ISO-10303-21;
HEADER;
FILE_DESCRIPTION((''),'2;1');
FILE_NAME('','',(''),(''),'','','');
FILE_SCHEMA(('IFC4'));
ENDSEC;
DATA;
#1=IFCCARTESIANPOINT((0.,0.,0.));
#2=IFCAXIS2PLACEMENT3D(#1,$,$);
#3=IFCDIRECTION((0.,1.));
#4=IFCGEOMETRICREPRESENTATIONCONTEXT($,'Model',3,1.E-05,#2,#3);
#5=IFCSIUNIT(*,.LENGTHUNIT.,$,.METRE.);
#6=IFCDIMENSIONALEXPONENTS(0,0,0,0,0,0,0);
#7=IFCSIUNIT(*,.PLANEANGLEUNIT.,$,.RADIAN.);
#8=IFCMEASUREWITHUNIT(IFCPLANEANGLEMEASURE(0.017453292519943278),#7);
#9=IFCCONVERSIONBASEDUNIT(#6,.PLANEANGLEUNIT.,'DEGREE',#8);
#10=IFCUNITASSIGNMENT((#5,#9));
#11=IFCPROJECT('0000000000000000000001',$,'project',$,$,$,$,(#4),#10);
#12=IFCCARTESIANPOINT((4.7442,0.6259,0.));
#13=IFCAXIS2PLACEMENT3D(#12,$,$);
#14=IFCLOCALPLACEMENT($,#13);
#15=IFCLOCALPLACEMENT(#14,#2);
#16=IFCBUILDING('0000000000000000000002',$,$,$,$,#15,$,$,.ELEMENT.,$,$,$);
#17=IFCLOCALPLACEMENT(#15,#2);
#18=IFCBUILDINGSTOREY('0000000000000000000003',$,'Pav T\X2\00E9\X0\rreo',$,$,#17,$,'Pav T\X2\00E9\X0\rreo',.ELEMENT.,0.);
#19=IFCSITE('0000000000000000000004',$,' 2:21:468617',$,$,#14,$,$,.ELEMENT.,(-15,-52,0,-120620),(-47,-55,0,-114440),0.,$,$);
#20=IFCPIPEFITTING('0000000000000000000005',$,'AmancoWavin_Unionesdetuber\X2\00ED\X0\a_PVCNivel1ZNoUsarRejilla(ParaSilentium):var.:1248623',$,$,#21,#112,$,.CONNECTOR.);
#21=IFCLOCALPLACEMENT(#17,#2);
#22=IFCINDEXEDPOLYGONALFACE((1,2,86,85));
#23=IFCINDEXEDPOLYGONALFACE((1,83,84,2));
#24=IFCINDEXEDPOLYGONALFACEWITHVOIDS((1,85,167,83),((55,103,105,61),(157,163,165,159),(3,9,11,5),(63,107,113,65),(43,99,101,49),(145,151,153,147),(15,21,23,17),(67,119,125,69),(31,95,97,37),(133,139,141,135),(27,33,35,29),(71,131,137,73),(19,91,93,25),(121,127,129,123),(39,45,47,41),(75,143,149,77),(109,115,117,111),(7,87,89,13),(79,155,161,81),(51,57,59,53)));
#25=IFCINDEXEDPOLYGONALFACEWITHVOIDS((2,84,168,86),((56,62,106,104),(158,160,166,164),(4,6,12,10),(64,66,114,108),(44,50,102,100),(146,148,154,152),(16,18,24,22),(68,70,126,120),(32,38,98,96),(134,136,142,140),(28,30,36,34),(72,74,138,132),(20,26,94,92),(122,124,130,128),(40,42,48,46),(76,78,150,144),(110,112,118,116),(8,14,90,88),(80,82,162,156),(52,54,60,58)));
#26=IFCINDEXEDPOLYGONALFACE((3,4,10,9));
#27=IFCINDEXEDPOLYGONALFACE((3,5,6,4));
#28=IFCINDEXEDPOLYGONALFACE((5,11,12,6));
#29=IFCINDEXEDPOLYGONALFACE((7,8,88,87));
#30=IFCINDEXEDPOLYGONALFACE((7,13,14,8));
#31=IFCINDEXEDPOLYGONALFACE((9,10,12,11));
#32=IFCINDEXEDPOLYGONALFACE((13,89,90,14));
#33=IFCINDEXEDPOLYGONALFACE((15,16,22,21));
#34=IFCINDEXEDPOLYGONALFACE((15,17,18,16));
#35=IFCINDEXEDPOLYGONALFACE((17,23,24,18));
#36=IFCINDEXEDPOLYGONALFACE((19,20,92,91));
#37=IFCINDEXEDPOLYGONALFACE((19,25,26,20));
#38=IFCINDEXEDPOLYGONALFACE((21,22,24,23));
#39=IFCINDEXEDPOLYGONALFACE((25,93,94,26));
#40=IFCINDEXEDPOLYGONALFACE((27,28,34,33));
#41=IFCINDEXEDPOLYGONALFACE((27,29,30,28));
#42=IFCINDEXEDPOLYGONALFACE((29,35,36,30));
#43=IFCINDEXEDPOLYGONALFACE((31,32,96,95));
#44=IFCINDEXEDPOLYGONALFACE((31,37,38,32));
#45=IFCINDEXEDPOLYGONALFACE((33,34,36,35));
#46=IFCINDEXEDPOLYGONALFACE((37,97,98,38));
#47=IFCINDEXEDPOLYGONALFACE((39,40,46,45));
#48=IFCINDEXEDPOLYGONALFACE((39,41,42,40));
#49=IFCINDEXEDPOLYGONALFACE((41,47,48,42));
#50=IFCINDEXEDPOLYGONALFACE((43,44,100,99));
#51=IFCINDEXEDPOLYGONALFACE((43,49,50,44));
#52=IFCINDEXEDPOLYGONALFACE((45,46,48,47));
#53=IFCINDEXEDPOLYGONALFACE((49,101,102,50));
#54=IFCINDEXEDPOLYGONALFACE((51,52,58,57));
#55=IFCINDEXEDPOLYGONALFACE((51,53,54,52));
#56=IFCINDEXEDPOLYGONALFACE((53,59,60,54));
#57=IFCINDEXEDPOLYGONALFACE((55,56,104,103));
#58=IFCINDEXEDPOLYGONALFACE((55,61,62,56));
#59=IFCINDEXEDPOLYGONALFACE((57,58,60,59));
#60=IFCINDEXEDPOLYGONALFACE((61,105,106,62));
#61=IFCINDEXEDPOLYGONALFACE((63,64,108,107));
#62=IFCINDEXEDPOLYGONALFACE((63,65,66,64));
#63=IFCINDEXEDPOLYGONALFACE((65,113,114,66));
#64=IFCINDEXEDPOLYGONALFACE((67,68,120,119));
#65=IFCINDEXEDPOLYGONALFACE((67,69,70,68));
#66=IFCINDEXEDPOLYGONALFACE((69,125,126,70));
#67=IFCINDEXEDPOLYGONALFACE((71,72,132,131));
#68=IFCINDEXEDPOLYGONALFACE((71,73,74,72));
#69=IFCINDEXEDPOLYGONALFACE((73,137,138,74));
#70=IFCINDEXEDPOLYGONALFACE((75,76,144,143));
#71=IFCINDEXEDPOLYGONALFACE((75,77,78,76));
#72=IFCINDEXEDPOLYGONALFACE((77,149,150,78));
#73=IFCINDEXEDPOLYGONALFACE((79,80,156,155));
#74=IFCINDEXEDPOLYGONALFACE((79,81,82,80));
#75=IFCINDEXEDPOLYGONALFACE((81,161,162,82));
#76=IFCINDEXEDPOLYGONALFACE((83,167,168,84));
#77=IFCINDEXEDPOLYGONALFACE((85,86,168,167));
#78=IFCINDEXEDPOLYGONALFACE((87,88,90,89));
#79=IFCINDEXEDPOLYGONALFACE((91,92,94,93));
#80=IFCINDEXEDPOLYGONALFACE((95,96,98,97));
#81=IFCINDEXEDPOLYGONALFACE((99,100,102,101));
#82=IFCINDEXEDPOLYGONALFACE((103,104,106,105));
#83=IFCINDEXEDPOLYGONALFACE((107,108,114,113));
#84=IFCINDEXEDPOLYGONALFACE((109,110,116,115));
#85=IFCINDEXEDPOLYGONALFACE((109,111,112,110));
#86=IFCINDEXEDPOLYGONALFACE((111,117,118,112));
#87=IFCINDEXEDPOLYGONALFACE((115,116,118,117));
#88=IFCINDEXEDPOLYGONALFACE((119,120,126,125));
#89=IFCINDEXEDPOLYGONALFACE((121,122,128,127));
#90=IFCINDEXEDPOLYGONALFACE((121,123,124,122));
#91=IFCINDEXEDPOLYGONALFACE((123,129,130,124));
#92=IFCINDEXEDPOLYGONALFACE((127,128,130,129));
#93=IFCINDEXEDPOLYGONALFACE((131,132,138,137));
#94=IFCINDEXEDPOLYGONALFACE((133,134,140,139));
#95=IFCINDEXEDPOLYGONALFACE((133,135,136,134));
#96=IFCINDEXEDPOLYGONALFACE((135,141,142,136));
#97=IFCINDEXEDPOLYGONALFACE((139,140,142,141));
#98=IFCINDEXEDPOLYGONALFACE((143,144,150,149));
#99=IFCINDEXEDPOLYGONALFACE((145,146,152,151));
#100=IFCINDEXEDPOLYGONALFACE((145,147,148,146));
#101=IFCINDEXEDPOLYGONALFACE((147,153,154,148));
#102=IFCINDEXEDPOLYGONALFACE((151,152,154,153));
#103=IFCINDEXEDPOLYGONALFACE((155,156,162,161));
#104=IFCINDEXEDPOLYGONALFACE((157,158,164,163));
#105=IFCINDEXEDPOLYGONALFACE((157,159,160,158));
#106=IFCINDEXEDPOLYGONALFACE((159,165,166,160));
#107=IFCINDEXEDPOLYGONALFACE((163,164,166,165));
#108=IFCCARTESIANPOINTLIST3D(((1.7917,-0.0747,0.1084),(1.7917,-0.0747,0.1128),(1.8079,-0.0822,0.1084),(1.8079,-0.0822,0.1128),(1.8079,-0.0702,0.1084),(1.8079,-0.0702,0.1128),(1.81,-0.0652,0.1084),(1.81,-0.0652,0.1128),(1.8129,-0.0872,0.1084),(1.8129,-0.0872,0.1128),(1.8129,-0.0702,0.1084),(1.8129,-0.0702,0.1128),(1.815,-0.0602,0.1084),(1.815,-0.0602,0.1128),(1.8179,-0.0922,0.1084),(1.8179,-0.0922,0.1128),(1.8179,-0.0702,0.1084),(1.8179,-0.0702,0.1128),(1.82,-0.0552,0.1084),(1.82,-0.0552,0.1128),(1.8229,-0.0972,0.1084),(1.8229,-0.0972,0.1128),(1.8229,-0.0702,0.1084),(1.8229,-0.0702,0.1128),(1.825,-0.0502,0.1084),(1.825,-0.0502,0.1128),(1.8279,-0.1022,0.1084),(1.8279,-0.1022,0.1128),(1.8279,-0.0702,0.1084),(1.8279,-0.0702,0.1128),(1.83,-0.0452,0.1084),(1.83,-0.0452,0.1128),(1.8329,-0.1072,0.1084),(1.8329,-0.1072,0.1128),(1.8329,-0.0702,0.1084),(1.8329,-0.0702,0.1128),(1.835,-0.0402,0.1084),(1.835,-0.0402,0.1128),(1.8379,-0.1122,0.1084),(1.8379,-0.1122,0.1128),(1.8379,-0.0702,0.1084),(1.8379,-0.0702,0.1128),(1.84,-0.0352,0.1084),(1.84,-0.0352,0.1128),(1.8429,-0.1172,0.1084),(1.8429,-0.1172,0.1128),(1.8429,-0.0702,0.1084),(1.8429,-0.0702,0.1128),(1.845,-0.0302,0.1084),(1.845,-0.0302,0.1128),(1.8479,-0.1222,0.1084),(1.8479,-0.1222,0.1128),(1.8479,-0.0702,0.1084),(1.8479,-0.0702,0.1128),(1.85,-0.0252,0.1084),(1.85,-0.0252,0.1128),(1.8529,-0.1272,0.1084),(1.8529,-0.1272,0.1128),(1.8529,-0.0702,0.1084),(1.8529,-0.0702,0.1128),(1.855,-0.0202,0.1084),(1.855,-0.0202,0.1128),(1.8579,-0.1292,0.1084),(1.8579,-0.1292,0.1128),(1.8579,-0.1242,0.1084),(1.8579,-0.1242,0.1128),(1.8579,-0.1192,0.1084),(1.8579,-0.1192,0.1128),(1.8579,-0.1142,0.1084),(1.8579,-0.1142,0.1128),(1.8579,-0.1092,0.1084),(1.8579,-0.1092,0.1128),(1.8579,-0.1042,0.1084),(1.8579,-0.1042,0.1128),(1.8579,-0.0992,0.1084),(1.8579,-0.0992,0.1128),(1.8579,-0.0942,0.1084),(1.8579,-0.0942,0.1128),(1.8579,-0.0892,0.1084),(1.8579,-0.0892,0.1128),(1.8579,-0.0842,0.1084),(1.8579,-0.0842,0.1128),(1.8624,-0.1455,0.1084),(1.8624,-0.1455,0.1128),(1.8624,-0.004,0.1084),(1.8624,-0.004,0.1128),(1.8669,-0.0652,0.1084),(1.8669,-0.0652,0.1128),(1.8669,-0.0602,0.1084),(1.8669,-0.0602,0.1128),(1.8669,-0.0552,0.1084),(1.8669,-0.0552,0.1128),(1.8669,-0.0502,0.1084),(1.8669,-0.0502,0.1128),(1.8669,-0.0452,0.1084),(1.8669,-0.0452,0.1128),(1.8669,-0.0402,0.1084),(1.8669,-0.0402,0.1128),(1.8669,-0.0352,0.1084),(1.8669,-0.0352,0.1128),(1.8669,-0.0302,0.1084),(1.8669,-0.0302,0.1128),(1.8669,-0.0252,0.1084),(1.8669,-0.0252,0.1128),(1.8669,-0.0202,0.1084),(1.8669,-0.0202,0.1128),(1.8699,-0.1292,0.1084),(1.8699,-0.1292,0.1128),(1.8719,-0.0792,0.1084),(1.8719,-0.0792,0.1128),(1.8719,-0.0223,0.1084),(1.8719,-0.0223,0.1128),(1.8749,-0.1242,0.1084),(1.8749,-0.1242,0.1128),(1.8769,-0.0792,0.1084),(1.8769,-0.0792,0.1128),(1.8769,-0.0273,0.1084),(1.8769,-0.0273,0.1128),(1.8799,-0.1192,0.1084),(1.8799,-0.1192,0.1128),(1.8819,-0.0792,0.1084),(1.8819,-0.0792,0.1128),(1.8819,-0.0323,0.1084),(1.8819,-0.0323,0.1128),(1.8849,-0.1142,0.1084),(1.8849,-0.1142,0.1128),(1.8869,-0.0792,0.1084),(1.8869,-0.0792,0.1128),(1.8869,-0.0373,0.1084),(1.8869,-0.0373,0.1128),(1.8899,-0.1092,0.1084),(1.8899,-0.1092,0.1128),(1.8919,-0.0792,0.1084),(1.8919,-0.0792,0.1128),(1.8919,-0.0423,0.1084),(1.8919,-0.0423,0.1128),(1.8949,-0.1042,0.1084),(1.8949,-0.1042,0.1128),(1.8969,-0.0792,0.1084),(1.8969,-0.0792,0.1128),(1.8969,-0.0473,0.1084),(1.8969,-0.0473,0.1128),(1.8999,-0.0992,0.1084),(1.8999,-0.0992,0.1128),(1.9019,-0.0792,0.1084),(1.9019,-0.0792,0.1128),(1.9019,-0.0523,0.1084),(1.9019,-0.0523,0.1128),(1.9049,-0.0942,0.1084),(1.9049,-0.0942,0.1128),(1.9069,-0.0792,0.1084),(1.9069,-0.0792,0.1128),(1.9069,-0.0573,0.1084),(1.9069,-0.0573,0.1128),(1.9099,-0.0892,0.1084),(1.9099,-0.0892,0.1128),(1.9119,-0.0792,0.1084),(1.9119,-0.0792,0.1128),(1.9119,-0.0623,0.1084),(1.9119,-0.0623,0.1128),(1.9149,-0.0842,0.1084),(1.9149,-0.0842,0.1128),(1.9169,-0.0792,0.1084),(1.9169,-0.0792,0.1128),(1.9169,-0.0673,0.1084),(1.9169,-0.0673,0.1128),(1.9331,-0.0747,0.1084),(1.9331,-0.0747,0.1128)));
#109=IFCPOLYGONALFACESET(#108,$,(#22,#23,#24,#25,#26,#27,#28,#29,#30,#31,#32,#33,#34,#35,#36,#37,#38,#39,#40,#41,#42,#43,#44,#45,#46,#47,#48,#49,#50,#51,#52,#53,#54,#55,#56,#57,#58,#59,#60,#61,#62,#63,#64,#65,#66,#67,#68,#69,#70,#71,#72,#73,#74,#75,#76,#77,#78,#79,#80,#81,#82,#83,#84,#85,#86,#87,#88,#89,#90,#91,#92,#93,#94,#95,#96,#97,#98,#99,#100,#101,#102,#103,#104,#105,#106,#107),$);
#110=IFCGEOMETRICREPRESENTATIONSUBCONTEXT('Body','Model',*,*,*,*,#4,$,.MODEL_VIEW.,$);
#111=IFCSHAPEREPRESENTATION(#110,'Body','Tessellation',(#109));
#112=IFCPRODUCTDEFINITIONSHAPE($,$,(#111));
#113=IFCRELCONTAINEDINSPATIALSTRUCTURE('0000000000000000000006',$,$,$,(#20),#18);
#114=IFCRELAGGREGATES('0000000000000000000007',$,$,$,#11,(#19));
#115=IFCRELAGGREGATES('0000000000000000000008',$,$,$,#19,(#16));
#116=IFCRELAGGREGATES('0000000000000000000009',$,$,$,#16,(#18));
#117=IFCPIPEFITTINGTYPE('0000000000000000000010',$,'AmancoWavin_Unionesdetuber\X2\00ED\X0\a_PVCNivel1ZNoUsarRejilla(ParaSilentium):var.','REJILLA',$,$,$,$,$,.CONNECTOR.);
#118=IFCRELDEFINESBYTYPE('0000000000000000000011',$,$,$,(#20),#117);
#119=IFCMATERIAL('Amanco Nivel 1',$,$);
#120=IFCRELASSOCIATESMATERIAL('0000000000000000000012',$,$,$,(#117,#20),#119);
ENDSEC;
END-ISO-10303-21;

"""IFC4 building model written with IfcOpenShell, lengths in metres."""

from ifc_helpers import new_model, entity, si_unit, converted_unit, direction, frame, origin, place, context, subcontext, project, spatial, indexed_curve, outline, extrude, source, transform, mapped, material, type_object, type_shapes, element, save


model = new_model("IFC4")

# Units and contexts
model_context = context("Model", 3, precision=1e-05, world=origin(), true_north=direction((0.0, 1.0)))
body_context = subcontext(model_context, "Body", "Model", "MODEL_VIEW")
ifc_project = project(units=[si_unit("LENGTHUNIT", "METRE"), converted_unit("PLANEANGLEUNIT", "DEGREE", entity("IfcPlaneAngleMeasure", 0.017453292519943278), si_unit("PLANEANGLEUNIT", "RADIAN"), dimensions=[0, 0, 0, 0, 0, 0, 0])], contexts=[model_context])

# Site, building, storey
site_placement = place(None, frame((4.7442, 0.6259, 0.0)))
site = spatial("IfcSite", under=ifc_project, at=site_placement, Name=" 2:21:468617", CompositionType="ELEMENT", RefLatitude=(-15, -52, 0, -120620), RefLongitude=(-47, -55, 0, -114440), RefElevation=0.0)
building_placement = place(site_placement, origin())
building = spatial("IfcBuilding", under=site, at=building_placement, CompositionType="ELEMENT")
storey_placement = place(building_placement, origin())
storey = spatial("IfcBuildingStorey", under=building, at=storey_placement, Name="Pav Térreo", LongName="Pav Térreo", CompositionType="ELEMENT", Elevation=0.0)

# Pipe fitting
ifc_material = material(Name="Amanco Nivel 1")
pipe_fitting_type = type_object("IfcPipeFittingType", Name="AmancoWavin_Unionesdetubería_PVCNivel1ZNoUsarRejilla(ParaSilentium):var.", Description="REJILLA", PredefinedType="CONNECTOR", material=ifc_material)
shared_shape = source(origin(), body_context, "Body", "SweptSolid", [
    extrude(outline(indexed_curve([(-0.05, -0.05), (0.05, -0.05), (0.05, 0.05), (-0.05, 0.05), (-0.05, -0.05)], self_intersect=False), holes=[indexed_curve([(0.0417, 0.0354), (0.0382, 0.0318), (0.0262, 0.0438), (0.0333, 0.0438), (0.0417, 0.0354)], self_intersect=False), indexed_curve([(0.0346, 0.0283), (0.0311, 0.0247), (0.0121, 0.0438), (0.0191, 0.0438), (0.0346, 0.0283)], self_intersect=False), indexed_curve([(0.0276, 0.0212), (0.024, 0.0177), (-0.0021, 0.0438), (0.005, 0.0438), (0.0276, 0.0212)], self_intersect=False), indexed_curve([(0.0205, 0.0141), (0.017, 0.0106), (-0.0162, 0.0438), (-0.0092, 0.0438), (0.0205, 0.0141)], self_intersect=False), indexed_curve([(0.0134, 0.0071), (0.0099, 0.0035), (-0.0304, 0.0438), (-0.0233, 0.0438), (0.0134, 0.0071)], self_intersect=False), indexed_curve([(-0.0354, 0.0417), (-0.0318, 0.0382), (-0.0438, 0.0262), (-0.0438, 0.0333), (-0.0354, 0.0417)], self_intersect=False), indexed_curve([(-0.0283, 0.0346), (-0.0247, 0.0311), (-0.0438, 0.0121), (-0.0438, 0.0191), (-0.0283, 0.0346)], self_intersect=False), indexed_curve([(-0.0212, 0.0276), (-0.0177, 0.024), (-0.0438, -0.0021), (-0.0438, 0.005), (-0.0212, 0.0276)], self_intersect=False), indexed_curve([(-0.0141, 0.0205), (-0.0106, 0.017), (-0.0438, -0.0162), (-0.0438, -0.0092), (-0.0141, 0.0205)], self_intersect=False), indexed_curve([(-0.0071, 0.0134), (-0.0035, 0.0099), (-0.0438, -0.0304), (-0.0438, -0.0233), (-0.0071, 0.0134)], self_intersect=False), indexed_curve([(-0.0417, -0.0354), (-0.0382, -0.0318), (-0.0262, -0.0438), (-0.0333, -0.0438), (-0.0417, -0.0354)], self_intersect=False), indexed_curve([(-0.0346, -0.0283), (-0.0311, -0.0247), (-0.0121, -0.0438), (-0.0191, -0.0438), (-0.0346, -0.0283)], self_intersect=False), indexed_curve([(-0.0276, -0.0212), (-0.024, -0.0177), (0.0021, -0.0438), (-0.005, -0.0438), (-0.0276, -0.0212)], self_intersect=False), indexed_curve([(-0.0205, -0.0141), (-0.017, -0.0106), (0.0162, -0.0438), (0.0092, -0.0438), (-0.0205, -0.0141)], self_intersect=False), indexed_curve([(-0.0134, -0.0071), (-0.0099, -0.0035), (0.0304, -0.0438), (0.0233, -0.0438), (-0.0134, -0.0071)], self_intersect=False), indexed_curve([(0.0354, -0.0417), (0.0318, -0.0382), (0.0438, -0.0262), (0.0438, -0.0333), (0.0354, -0.0417)], self_intersect=False), indexed_curve([(0.0283, -0.0346), (0.0247, -0.0311), (0.0438, -0.0121), (0.0438, -0.0191), (0.0283, -0.0346)], self_intersect=False), indexed_curve([(0.0212, -0.0276), (0.0177, -0.024), (0.0438, 0.0021), (0.0438, -0.005), (0.0212, -0.0276)], self_intersect=False), indexed_curve([(0.0141, -0.0205), (0.0106, -0.017), (0.0438, 0.0162), (0.0438, 0.0092), (0.0141, -0.0205)], self_intersect=False), indexed_curve([(0.0071, -0.0134), (0.0035, -0.0099), (0.0438, 0.0304), (0.0438, 0.0233), (0.0071, -0.0134)], self_intersect=False)]), frame((-0.0692, 0.0, -0.0042), z_axis=(0.0, 0.0, 1.0), x_axis=(-1.0, 0.0, 0.0)), (0.0, 0.0, 1.0), 0.0044),
])
type_shapes(pipe_fitting_type, [shared_shape])
pipe_fitting_placement = place(storey_placement, frame((1.9114, -0.1237, 0.1126), z_axis=(0.0, 0.0, 1.0), x_axis=(0.707107, -0.707107, 0.0)))
element("IfcPipeFitting", 1, at=pipe_fitting_placement, inside=storey, type_object=pipe_fitting_type, material=ifc_material, Name="AmancoWavin_Unionesdetubería_PVCNivel1ZNoUsarRejilla(ParaSilentium):var.:1248623", PredefinedType="CONNECTOR", context=body_context, shape_type="MappedRepresentation", body=[
    mapped(shared_shape, transform((0.0, 0.0, 0.0), scale=1.0)),
])

save(model, "model.ifc")
